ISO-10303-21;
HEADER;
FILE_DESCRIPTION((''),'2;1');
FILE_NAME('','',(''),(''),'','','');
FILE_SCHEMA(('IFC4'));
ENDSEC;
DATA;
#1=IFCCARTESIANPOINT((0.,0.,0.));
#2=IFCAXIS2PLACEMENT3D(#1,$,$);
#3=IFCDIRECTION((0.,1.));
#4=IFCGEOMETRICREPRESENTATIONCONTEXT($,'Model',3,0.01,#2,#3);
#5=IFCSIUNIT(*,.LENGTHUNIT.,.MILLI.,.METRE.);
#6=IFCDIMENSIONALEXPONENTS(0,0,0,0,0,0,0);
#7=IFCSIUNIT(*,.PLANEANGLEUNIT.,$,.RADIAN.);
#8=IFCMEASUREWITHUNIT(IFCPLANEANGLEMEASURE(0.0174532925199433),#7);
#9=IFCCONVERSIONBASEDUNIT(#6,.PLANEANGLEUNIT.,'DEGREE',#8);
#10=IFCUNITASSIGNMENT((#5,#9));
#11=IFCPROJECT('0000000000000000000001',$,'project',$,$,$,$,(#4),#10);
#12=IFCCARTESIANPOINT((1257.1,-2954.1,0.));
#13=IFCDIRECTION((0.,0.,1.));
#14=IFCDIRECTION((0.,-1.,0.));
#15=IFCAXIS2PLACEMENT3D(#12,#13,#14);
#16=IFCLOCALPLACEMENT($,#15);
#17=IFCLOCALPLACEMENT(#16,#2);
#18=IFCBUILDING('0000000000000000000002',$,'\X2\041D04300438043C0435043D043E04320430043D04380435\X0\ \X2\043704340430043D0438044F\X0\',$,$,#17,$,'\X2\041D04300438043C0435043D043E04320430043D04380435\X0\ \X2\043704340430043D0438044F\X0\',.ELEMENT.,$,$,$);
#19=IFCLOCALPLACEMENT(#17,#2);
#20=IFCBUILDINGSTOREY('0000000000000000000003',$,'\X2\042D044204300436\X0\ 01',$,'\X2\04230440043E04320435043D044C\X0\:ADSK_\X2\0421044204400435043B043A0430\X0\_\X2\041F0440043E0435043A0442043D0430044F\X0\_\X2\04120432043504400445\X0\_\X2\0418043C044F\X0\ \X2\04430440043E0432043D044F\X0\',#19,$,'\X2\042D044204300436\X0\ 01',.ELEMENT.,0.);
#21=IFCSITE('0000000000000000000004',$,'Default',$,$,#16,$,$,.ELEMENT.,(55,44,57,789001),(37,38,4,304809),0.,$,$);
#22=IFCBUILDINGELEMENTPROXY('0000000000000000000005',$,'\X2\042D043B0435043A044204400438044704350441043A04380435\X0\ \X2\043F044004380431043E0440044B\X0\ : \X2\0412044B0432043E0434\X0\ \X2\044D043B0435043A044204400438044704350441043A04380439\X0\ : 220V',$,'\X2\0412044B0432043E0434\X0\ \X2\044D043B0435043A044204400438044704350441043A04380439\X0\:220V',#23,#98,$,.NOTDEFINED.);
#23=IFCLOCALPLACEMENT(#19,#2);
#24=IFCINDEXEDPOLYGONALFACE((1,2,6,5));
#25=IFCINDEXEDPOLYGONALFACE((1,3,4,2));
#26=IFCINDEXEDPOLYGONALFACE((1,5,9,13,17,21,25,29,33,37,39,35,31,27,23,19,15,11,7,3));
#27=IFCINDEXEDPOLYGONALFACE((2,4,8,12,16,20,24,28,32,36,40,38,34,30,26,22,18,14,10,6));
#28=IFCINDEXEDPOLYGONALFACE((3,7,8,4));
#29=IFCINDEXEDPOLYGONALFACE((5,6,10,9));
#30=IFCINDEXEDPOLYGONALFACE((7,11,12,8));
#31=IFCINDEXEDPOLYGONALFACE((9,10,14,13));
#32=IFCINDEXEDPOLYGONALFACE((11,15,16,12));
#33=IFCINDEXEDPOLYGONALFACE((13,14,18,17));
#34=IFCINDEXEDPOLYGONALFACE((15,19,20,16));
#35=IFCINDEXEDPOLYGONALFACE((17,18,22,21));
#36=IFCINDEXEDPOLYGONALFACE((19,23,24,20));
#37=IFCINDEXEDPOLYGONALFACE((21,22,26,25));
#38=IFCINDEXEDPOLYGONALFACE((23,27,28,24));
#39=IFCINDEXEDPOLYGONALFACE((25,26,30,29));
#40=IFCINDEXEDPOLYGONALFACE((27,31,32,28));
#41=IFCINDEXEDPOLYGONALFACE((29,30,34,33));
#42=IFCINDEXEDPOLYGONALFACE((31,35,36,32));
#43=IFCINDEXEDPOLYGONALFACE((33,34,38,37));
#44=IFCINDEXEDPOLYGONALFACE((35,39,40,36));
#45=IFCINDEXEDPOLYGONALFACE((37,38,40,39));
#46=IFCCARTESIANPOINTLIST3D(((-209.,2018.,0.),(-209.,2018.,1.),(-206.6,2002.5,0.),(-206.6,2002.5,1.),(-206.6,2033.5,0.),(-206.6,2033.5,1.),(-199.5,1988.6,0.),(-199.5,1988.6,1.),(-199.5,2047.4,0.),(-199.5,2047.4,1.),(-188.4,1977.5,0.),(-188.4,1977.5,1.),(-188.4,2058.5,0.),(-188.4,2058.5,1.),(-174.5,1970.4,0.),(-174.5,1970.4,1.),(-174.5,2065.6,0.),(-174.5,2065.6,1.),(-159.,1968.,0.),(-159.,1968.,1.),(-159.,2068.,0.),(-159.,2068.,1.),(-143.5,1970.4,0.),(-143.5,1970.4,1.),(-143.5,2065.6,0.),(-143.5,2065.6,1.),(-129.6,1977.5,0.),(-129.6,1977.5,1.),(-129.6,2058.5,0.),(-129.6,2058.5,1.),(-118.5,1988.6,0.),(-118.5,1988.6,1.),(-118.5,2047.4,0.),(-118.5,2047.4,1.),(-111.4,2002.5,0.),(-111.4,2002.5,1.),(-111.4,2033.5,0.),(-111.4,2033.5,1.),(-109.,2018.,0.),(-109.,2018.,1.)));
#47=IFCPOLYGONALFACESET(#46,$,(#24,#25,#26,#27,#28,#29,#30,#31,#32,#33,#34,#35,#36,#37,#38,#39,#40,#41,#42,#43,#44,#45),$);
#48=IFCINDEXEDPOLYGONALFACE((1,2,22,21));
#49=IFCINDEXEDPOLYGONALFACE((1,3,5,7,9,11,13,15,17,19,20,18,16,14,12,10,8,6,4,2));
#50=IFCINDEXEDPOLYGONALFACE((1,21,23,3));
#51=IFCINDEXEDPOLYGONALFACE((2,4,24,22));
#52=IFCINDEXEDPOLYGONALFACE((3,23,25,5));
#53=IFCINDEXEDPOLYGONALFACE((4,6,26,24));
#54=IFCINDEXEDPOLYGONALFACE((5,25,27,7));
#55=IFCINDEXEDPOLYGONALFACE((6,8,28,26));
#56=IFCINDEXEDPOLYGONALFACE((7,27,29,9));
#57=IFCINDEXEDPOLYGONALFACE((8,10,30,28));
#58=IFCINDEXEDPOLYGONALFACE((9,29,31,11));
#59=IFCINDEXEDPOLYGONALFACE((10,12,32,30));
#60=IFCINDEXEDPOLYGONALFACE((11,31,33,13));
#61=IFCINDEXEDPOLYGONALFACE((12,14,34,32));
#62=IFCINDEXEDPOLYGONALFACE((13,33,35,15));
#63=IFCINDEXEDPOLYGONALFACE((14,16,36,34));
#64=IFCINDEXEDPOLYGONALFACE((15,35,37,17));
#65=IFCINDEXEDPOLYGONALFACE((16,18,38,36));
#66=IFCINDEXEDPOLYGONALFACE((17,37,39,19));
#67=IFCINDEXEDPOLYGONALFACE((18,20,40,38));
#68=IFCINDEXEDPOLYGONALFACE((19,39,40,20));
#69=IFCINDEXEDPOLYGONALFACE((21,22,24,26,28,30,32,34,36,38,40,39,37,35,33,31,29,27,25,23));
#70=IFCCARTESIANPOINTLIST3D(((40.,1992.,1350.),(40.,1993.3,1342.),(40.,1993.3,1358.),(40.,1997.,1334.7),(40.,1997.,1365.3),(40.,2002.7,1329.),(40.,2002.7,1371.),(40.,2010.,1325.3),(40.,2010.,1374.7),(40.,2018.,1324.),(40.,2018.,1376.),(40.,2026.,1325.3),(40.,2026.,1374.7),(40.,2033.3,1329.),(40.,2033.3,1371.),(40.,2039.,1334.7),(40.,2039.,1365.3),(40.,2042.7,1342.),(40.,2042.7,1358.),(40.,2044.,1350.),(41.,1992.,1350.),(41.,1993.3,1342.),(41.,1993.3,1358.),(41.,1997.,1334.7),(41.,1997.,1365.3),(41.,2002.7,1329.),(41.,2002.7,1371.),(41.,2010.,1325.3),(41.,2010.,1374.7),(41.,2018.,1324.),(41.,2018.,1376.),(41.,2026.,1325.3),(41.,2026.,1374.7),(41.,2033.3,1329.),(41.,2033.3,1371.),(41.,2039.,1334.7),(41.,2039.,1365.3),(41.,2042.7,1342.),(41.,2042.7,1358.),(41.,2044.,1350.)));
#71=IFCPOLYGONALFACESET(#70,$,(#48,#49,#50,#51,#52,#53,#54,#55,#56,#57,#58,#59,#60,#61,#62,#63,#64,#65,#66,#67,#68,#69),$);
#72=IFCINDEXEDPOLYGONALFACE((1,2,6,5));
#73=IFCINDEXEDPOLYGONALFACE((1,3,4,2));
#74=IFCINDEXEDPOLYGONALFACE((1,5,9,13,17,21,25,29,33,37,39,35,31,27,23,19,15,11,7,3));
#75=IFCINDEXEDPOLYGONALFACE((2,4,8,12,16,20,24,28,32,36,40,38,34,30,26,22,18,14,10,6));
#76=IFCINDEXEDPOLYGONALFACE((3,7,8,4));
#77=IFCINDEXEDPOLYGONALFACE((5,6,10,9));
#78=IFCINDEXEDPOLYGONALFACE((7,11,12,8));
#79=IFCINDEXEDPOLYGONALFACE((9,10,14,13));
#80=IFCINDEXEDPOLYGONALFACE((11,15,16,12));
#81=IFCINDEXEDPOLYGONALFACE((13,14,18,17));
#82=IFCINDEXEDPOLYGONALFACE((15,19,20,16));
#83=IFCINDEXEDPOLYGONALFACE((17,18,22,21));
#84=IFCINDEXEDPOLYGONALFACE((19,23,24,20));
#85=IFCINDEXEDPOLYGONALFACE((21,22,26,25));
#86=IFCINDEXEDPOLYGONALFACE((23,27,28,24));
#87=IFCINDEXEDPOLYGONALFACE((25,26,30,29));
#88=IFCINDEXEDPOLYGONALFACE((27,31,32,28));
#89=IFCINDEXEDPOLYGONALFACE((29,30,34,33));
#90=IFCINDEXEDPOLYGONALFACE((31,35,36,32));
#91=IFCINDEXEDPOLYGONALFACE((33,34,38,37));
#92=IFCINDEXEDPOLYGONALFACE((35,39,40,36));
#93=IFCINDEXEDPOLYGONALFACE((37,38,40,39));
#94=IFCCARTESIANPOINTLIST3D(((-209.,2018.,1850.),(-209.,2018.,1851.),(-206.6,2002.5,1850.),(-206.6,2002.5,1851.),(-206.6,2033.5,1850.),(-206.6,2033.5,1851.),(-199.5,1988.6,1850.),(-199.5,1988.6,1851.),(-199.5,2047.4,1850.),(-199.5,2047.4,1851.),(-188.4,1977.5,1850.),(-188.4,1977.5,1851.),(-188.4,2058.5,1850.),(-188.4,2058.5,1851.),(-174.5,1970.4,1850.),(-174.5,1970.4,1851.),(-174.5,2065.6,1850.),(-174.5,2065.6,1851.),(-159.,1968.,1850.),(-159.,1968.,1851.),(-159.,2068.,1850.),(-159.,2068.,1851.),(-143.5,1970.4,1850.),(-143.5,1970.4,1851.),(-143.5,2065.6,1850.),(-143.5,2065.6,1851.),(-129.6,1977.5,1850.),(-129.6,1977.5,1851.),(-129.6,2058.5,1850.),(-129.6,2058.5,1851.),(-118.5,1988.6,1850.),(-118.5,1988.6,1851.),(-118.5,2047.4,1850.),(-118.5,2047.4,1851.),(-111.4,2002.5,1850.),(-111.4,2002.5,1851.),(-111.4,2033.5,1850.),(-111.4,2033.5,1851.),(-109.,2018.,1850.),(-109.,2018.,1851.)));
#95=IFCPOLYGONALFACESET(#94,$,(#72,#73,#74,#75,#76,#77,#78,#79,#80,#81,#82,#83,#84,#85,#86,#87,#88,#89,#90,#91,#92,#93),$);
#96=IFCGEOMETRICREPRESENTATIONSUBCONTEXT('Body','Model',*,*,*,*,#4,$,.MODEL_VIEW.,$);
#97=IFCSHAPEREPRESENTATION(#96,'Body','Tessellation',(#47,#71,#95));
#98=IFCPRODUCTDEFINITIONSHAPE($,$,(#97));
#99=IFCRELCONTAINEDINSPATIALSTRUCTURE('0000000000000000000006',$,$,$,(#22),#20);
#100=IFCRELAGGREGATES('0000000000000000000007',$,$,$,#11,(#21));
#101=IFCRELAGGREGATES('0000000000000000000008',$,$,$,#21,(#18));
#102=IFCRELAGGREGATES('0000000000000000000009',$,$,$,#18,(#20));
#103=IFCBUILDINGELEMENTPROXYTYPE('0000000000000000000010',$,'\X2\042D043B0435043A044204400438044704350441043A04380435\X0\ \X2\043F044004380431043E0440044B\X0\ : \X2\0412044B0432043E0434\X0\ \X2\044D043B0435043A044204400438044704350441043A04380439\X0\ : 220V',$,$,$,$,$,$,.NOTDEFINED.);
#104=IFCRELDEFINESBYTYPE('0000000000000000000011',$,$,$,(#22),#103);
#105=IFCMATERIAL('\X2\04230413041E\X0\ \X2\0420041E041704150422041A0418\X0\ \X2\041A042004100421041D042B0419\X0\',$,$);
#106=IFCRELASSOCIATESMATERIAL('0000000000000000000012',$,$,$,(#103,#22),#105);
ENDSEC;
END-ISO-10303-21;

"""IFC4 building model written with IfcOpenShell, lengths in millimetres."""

from ifc_helpers import new_model, entity, si_unit, converted_unit, direction, frame, origin, place, context, subcontext, project, spatial, indexed_curve, outline, extrude, source, transform, mapped, material, type_object, type_shapes, element, save


model = new_model("IFC4")

# Units and contexts
model_context = context("Model", 3, precision=0.01, world=origin(), true_north=direction((0.0, 1.0)))
body_context = subcontext(model_context, "Body", "Model", "MODEL_VIEW")
ifc_project = project(units=[si_unit("LENGTHUNIT", "METRE", prefix="MILLI"), converted_unit("PLANEANGLEUNIT", "DEGREE", entity("IfcPlaneAngleMeasure", 0.0174532925199433), si_unit("PLANEANGLEUNIT", "RADIAN"), dimensions=[0, 0, 0, 0, 0, 0, 0])], contexts=[model_context])

# Site, building, storey
site_placement = place(None, frame((1257.1, -2954.1, 0.0), z_axis=(0.0, 0.0, 1.0), x_axis=(0.0, -1.0, 0.0)))
site = spatial("IfcSite", under=ifc_project, at=site_placement, Name="Default", CompositionType="ELEMENT", RefLatitude=(55, 44, 57, 789001), RefLongitude=(37, 38, 4, 304809), RefElevation=0.0)
building_placement = place(site_placement, origin())
building = spatial("IfcBuilding", under=site, at=building_placement, Name="Наименование здания", LongName="Наименование здания", CompositionType="ELEMENT")
storey_placement = place(building_placement, origin())
storey = spatial("IfcBuildingStorey", under=building, at=storey_placement, Name="Этаж 01", ObjectType="Уровень:ADSK_Стрелка_Проектная_Вверх_Имя уровня", LongName="Этаж 01", CompositionType="ELEMENT", Elevation=0.0)

# Building element proxy
ifc_material_1 = material(Name="УГО РОЗЕТКИ КРАСНЫЙ")
building_element_proxy_type_1 = type_object("IfcBuildingElementProxyType", Name="Электрические приборы : Вывод электрический : 220V", PredefinedType="NOTDEFINED", material=ifc_material_1)
shared_shape_1 = source(origin(), body_context, "Body", "SweptSolid", [
    extrude(outline(indexed_curve([(50.0, 0.0), (47.6, 15.5), (40.5, 29.4), (29.4, 40.5), (15.5, 47.6), (0.0, 50.0), (-15.5, 47.6), (-29.4, 40.5), (-40.5, 29.4), (-47.6, 15.5), (-50.0, 0.0), (-47.6, -15.5), (-40.5, -29.4), (-29.4, -40.5), (-15.5, -47.6), (0.0, -50.0), (15.5, -47.6), (29.4, -40.5), (40.5, -29.4), (47.6, -15.5), (50.0, 0.0)], self_intersect=False)), frame((0.0, -200.0, 0.0), z_axis=(0.0, 0.0, 1.0), x_axis=(-1.0, 0.0, 0.0)), (0.0, 0.0, 1.0), 1.0),
    extrude(outline(indexed_curve([(26.0, 0.0), (24.7, 8.0), (21.0, 15.3), (15.3, 21.0), (8.0, 24.7), (0.0, 26.0), (-8.0, 24.7), (-15.3, 21.0), (-21.0, 15.3), (-24.7, 8.0), (-26.0, 0.0), (-24.7, -8.0), (-21.0, -15.3), (-15.3, -21.0), (-8.0, -24.7), (0.0, -26.0), (8.0, -24.7), (15.3, -21.0), (21.0, -15.3), (24.7, -8.0), (26.0, 0.0)], self_intersect=False)), frame((0.0, -1.0, 1350.0), z_axis=(0.0, 1.0, 0.0), x_axis=(1.0, 0.0, 0.0)), (0.0, 0.0, 1.0), 1.0),
    extrude(outline(indexed_curve([(50.0, 0.0), (47.6, 15.5), (40.5, 29.4), (29.4, 40.5), (15.5, 47.6), (0.0, 50.0), (-15.5, 47.6), (-29.4, 40.5), (-40.5, 29.4), (-47.6, 15.5), (-50.0, 0.0), (-47.6, -15.5), (-40.5, -29.4), (-29.4, -40.5), (-15.5, -47.6), (0.0, -50.0), (15.5, -47.6), (29.4, -40.5), (40.5, -29.4), (47.6, -15.5), (50.0, 0.0)], self_intersect=False)), frame((0.0, -200.0, 1850.0), z_axis=(0.0, 0.0, 1.0), x_axis=(-1.0, 0.0, 0.0)), (0.0, 0.0, 1.0), 1.0),
])
type_shapes(building_element_proxy_type_1, [shared_shape_1])
proxy_1_placement = place(storey_placement, frame((41.0, 2018.0, 0.0), z_axis=(0.0, 0.0, 1.0), x_axis=(0.0, -1.0, 0.0)))
element("IfcBuildingElementProxy", 1, at=proxy_1_placement, inside=storey, type_object=building_element_proxy_type_1, material=ifc_material_1, Name="Электрические приборы : Вывод электрический : 220V", ObjectType="Вывод электрический:220V", PredefinedType="NOTDEFINED", context=body_context, shape_type="MappedRepresentation", body=[
    mapped(shared_shape_1, transform((0.0, 0.0, 0.0), scale=1.0)),
])

save(model, "model.ifc")
